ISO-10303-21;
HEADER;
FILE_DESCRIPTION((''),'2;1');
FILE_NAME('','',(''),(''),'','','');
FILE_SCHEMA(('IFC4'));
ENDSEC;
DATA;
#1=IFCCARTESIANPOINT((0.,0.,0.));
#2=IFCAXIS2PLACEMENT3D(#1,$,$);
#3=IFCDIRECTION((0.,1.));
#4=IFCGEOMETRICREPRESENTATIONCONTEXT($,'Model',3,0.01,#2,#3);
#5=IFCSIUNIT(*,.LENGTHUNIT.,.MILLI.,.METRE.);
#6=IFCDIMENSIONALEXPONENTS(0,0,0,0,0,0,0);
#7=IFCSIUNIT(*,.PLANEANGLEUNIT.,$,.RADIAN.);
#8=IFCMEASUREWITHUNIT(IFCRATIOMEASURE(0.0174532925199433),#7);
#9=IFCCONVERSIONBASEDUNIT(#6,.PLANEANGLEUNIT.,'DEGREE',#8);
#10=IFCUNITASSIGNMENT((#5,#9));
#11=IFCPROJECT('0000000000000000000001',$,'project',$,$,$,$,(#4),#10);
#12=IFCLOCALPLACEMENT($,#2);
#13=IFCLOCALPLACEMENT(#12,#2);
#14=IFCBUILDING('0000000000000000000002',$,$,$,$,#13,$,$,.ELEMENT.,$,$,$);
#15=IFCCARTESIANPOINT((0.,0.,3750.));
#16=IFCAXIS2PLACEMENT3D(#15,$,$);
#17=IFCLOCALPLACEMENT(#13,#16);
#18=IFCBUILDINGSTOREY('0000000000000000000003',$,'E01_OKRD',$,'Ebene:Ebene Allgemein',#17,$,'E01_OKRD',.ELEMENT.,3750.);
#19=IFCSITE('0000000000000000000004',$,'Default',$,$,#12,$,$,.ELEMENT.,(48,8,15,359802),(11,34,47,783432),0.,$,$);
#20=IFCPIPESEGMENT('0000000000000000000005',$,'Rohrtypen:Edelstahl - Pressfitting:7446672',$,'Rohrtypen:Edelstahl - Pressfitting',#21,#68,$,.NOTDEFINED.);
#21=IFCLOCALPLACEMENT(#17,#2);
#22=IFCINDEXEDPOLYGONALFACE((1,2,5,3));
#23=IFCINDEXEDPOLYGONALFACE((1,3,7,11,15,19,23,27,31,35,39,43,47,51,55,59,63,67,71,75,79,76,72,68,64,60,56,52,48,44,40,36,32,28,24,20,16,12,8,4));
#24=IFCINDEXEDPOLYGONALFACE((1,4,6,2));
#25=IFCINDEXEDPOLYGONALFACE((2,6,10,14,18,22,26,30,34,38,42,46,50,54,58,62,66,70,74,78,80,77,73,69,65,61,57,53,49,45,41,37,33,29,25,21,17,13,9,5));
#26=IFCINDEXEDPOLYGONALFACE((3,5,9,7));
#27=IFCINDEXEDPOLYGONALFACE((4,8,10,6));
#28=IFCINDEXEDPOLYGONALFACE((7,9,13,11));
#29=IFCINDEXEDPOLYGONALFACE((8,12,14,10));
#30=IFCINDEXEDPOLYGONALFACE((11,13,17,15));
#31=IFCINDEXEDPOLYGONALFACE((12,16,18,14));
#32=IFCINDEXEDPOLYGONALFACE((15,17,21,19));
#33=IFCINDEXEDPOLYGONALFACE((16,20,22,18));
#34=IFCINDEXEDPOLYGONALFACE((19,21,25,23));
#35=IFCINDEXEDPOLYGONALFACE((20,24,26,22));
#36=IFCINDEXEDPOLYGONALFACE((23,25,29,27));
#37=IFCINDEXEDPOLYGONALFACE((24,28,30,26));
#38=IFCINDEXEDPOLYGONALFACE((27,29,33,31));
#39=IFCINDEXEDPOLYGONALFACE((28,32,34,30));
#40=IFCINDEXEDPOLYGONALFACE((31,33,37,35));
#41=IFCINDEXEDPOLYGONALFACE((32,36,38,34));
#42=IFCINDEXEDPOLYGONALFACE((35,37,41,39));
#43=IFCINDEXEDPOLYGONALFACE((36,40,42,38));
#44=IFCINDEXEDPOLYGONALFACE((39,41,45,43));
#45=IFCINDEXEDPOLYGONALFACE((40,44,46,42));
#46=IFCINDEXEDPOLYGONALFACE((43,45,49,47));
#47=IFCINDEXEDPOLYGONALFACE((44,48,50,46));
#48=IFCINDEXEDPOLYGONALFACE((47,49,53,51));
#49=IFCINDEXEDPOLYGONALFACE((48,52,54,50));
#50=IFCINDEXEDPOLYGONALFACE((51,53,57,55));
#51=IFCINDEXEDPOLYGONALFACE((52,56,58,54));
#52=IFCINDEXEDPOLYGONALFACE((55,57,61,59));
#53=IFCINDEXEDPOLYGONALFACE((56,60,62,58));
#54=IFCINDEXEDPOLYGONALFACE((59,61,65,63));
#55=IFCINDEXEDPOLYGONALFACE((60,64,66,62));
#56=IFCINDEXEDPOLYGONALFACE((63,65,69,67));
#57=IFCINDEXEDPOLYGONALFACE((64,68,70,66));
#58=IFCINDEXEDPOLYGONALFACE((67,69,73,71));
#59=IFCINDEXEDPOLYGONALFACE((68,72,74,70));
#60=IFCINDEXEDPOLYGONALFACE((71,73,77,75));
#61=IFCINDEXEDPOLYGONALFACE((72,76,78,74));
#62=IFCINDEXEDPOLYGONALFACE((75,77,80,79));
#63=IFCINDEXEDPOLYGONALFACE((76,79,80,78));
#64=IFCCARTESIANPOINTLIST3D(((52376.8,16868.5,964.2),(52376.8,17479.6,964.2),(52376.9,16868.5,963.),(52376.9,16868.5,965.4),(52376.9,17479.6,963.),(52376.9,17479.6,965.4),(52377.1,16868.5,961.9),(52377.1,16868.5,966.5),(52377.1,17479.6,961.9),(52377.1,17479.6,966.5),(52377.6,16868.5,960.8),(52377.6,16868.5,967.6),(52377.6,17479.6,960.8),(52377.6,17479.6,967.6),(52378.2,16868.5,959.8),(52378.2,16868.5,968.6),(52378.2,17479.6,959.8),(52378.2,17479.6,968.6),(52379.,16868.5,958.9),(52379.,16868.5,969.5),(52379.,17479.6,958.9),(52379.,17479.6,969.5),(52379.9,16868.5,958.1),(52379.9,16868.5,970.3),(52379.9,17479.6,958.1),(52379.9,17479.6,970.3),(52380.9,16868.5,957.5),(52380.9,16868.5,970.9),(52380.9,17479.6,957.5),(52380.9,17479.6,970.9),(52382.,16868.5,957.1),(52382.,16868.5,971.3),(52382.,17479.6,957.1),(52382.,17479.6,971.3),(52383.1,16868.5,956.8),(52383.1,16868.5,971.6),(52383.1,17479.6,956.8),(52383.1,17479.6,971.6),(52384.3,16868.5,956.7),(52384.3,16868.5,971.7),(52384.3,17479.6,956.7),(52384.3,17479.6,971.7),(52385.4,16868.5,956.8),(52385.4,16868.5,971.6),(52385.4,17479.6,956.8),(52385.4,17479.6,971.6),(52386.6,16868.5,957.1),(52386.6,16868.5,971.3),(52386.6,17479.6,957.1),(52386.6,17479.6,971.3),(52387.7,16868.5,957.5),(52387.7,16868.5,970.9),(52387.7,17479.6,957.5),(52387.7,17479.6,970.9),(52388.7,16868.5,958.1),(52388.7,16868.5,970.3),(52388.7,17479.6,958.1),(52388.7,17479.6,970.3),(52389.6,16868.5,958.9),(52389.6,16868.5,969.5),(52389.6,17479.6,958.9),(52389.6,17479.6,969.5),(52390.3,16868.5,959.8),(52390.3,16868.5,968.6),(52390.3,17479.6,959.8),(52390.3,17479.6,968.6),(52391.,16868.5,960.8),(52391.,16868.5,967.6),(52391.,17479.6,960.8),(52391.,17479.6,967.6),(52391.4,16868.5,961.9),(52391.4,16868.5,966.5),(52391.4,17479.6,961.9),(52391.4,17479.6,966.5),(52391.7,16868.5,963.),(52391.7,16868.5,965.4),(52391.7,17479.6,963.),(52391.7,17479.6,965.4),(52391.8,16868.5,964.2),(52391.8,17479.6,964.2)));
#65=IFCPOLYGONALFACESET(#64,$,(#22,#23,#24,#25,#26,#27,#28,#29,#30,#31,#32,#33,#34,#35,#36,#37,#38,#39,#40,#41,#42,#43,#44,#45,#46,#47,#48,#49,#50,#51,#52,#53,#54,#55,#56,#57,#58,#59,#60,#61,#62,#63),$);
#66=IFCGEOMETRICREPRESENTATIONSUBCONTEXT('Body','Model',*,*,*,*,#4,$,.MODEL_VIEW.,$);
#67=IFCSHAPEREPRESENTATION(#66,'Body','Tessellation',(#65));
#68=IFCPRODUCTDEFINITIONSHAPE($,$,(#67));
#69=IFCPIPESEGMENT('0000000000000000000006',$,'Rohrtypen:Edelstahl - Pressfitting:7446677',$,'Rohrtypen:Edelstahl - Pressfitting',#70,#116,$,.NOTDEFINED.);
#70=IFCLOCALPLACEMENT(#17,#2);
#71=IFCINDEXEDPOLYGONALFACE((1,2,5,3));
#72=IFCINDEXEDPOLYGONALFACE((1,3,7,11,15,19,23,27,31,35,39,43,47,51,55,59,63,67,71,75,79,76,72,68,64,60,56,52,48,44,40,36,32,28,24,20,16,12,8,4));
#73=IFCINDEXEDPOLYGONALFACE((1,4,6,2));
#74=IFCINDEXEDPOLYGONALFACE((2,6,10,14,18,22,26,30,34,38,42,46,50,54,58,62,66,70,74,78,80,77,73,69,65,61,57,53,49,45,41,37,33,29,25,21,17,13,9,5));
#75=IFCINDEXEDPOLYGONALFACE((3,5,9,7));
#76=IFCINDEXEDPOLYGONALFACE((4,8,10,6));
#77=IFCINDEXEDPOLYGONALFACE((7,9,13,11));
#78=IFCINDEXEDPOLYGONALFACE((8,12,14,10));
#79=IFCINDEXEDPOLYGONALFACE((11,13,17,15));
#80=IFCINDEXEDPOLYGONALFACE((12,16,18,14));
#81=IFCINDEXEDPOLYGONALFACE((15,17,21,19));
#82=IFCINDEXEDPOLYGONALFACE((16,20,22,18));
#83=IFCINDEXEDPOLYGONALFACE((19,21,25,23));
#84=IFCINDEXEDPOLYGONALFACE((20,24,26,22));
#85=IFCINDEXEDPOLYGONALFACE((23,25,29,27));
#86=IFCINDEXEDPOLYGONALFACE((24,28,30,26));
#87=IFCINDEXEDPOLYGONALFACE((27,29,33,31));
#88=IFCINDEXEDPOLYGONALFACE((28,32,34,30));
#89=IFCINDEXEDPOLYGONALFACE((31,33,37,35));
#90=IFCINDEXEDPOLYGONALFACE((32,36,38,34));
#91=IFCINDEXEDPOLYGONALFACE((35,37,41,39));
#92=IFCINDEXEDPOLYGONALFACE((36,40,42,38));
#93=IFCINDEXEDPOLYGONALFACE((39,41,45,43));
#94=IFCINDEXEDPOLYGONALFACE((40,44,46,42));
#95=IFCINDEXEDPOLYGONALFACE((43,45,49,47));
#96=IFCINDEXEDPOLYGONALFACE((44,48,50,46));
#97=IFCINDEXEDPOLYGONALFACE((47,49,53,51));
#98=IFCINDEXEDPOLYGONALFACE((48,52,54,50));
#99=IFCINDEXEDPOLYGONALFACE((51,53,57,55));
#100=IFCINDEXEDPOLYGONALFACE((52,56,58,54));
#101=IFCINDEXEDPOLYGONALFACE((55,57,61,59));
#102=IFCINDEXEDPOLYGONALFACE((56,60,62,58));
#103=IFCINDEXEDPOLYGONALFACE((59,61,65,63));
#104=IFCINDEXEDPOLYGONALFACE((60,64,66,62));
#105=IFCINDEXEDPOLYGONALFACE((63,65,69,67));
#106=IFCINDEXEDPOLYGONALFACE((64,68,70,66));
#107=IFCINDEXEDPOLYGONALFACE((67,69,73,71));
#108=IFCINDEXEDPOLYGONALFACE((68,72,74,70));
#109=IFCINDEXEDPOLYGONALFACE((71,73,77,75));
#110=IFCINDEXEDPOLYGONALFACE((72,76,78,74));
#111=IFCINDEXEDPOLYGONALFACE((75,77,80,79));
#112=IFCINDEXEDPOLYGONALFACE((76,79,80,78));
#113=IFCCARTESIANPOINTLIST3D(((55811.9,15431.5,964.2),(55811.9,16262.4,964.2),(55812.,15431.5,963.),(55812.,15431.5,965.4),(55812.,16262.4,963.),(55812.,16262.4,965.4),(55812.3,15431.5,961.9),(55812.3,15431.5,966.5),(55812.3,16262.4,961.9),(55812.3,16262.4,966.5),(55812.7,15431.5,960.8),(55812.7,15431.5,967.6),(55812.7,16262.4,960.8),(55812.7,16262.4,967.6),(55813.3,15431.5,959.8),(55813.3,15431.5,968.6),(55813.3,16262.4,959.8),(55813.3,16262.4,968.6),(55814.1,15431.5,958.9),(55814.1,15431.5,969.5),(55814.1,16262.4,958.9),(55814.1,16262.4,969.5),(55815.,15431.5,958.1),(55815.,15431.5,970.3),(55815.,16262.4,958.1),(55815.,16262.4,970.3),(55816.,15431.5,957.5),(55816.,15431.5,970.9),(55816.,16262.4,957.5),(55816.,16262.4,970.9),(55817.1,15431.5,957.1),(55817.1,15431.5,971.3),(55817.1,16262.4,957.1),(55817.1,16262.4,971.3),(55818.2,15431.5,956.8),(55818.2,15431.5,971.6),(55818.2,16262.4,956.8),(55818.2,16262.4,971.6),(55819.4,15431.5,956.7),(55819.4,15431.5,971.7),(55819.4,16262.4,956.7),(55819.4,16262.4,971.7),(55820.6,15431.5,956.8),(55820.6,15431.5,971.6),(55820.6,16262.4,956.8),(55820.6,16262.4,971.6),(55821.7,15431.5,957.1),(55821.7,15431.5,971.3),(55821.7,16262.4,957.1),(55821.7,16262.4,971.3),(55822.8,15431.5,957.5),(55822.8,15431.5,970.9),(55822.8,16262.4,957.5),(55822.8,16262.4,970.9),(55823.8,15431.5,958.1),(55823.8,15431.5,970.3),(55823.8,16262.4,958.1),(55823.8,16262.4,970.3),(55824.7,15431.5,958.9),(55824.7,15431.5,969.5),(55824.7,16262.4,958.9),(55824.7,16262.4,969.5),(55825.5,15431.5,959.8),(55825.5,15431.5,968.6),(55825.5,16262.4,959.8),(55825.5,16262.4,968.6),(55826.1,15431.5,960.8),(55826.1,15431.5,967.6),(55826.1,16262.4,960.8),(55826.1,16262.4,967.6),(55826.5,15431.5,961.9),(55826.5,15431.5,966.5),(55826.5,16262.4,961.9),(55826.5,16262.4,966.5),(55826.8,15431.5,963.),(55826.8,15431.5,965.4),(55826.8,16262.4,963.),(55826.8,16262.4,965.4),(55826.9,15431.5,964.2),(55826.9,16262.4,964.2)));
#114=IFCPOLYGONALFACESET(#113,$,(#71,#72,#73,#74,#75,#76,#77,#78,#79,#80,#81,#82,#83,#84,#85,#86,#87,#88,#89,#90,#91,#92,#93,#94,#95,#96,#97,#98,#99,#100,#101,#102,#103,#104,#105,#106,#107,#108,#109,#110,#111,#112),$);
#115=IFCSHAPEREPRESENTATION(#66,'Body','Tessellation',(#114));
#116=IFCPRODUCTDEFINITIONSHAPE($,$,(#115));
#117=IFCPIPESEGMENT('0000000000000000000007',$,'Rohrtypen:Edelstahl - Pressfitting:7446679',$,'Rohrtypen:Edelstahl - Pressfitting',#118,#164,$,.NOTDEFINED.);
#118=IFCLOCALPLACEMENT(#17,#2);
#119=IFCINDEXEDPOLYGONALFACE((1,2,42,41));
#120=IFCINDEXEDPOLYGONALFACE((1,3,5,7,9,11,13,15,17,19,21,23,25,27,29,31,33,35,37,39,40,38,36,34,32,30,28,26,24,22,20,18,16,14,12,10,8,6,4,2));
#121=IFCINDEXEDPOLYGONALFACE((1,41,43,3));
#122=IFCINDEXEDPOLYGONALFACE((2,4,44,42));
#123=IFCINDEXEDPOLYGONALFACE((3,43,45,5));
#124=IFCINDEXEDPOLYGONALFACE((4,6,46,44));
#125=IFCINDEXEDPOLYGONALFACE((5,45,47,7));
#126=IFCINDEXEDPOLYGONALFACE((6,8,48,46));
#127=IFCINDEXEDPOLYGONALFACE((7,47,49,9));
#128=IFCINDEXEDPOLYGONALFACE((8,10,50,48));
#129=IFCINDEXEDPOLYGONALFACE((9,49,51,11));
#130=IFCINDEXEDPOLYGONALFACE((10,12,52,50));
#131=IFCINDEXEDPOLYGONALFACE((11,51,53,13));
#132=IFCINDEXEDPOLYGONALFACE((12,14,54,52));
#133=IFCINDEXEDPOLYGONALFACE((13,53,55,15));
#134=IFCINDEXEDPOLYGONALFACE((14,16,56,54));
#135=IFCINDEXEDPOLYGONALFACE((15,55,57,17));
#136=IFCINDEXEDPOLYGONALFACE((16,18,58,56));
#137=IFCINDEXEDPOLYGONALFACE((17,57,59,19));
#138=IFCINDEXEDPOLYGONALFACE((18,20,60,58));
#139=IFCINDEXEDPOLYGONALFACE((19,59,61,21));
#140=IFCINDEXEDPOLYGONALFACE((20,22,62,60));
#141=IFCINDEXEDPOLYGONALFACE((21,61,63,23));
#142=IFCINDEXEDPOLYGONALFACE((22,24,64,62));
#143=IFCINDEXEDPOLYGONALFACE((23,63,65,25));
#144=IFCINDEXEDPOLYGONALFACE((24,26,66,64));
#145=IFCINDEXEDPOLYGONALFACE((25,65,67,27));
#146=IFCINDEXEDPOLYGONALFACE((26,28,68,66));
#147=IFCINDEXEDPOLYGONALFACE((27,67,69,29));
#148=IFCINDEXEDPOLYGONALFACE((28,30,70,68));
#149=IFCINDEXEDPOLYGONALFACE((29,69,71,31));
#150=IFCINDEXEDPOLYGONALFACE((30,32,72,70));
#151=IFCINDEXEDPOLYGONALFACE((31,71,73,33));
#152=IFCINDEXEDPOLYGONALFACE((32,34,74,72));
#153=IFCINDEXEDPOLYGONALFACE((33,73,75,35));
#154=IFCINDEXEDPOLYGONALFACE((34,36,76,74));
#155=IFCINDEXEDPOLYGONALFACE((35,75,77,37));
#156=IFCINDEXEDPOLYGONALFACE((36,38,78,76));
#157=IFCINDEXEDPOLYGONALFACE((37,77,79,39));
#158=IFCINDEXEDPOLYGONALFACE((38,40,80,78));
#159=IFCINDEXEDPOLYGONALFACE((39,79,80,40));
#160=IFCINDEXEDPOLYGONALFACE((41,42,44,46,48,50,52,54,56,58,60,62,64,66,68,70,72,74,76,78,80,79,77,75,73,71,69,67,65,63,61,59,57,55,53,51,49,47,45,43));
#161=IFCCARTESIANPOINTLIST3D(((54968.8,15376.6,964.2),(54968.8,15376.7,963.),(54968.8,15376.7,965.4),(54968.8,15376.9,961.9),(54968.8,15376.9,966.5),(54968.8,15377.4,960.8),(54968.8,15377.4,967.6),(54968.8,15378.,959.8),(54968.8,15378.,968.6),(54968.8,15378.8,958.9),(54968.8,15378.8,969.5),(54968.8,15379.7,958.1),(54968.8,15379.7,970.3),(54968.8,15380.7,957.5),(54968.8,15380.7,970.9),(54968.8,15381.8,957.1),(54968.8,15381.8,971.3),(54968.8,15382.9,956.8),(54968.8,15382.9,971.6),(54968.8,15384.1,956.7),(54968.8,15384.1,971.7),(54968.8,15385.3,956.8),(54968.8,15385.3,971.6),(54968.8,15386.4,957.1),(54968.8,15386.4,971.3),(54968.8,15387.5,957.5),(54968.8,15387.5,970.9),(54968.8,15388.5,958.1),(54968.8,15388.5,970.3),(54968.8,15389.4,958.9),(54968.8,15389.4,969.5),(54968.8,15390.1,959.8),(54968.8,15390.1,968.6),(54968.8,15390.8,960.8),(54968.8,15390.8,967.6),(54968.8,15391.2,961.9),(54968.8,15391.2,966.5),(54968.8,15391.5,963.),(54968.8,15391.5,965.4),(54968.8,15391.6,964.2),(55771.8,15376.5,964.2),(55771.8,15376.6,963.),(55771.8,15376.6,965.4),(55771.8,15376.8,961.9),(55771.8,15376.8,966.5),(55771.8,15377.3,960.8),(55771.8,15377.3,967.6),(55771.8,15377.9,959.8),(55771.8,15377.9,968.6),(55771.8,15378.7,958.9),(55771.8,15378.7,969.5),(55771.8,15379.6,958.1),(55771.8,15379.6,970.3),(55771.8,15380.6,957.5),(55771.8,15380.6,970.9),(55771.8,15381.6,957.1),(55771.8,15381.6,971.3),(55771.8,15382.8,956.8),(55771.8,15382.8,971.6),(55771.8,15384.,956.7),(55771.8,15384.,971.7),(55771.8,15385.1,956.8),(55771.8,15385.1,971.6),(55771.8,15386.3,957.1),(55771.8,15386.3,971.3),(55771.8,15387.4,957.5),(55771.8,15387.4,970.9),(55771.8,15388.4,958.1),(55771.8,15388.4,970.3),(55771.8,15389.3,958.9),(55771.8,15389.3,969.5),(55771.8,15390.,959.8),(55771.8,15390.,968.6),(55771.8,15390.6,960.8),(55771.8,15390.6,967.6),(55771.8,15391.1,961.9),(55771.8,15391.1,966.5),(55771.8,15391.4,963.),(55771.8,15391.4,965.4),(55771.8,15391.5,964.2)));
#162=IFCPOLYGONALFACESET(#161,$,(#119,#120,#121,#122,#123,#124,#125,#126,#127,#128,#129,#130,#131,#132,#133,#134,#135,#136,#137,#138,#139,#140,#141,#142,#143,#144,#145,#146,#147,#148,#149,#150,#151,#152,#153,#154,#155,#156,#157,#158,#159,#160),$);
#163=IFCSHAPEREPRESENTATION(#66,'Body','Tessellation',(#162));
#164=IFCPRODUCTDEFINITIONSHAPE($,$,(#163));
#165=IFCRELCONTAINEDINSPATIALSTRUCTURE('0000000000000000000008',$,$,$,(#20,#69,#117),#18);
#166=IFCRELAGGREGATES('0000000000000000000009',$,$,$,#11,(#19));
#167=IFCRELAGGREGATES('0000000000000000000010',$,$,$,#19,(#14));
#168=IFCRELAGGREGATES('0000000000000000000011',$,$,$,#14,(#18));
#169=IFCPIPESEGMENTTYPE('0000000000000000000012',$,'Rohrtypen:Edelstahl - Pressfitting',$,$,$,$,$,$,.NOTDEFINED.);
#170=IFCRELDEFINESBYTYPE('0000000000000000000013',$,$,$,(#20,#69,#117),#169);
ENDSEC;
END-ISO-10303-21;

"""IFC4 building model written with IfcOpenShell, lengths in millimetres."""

from ifc_helpers import new_model, entity, si_unit, converted_unit, direction, frame, origin, place, context, subcontext, project, spatial, indexed_curve, outline, extrude, type_object, element, save


model = new_model("IFC4")

# Units and contexts
model_context = context("Model", 3, precision=0.01, world=origin(), true_north=direction((0.0, 1.0)))
body_context = subcontext(model_context, "Body", "Model", "MODEL_VIEW")
ifc_project = project(units=[si_unit("LENGTHUNIT", "METRE", prefix="MILLI"), converted_unit("PLANEANGLEUNIT", "DEGREE", entity("IfcRatioMeasure", 0.0174532925199433), si_unit("PLANEANGLEUNIT", "RADIAN"), dimensions=[0, 0, 0, 0, 0, 0, 0])], contexts=[model_context])

# Site, building, storey
site_placement = place(None, origin())
site = spatial("IfcSite", under=ifc_project, at=site_placement, Name="Default", CompositionType="ELEMENT", RefLatitude=(48, 8, 15, 359802), RefLongitude=(11, 34, 47, 783432), RefElevation=0.0)
building_placement = place(site_placement, origin())
building = spatial("IfcBuilding", under=site, at=building_placement, CompositionType="ELEMENT")
storey_placement = place(building_placement, frame((0.0, 0.0, 3750.0)))
storey = spatial("IfcBuildingStorey", under=building, at=storey_placement, Name="E01_OKRD", ObjectType="Ebene:Ebene Allgemein", LongName="E01_OKRD", CompositionType="ELEMENT", Elevation=3750.0)

# Pipe segments
pipe_segment_type_1 = type_object("IfcPipeSegmentType", Name="Rohrtypen:Edelstahl - Pressfitting", PredefinedType="NOTDEFINED")
pipe_segment_1_placement = place(storey_placement, origin())
element("IfcPipeSegment", 1, at=pipe_segment_1_placement, inside=storey, type_object=pipe_segment_type_1, Name="Rohrtypen:Edelstahl - Pressfitting:7446672", ObjectType="Rohrtypen:Edelstahl - Pressfitting", PredefinedType="NOTDEFINED", context=body_context, shape_type="SweptSolid", body=[
    extrude(outline(indexed_curve([(7.5, 0.0), (7.4, 1.2), (7.1, 2.3), (6.7, 3.4), (6.1, 4.4), (5.3, 5.3), (4.4, 6.1), (3.4, 6.7), (2.3, 7.1), (1.2, 7.4), (0.0, 7.5), (-1.2, 7.4), (-2.3, 7.1), (-3.4, 6.7), (-4.4, 6.1), (-5.3, 5.3), (-6.1, 4.4), (-6.7, 3.4), (-7.1, 2.3), (-7.4, 1.2), (-7.5, 0.0), (-7.4, -1.2), (-7.1, -2.3), (-6.7, -3.4), (-6.1, -4.4), (-5.3, -5.3), (-4.4, -6.1), (-3.4, -6.7), (-2.3, -7.1), (-1.2, -7.4), (0.0, -7.5), (1.2, -7.4), (2.3, -7.1), (3.4, -6.7), (4.4, -6.1), (5.3, -5.3), (6.1, -4.4), (6.7, -3.4), (7.1, -2.3), (7.4, -1.2), (7.5, 0.0)], self_intersect=False)), frame((52384.3, 16868.5, 964.2), z_axis=(0.000001, 1.0, 0.0), x_axis=(1.0, -0.000001, 0.0)), (0.0, 0.0, 1.0), 611.0),
])
pipe_segment_2_placement = place(storey_placement, origin())
element("IfcPipeSegment", 2, at=pipe_segment_2_placement, inside=storey, type_object=pipe_segment_type_1, Name="Rohrtypen:Edelstahl - Pressfitting:7446677", ObjectType="Rohrtypen:Edelstahl - Pressfitting", PredefinedType="NOTDEFINED", context=body_context, shape_type="SweptSolid", body=[
    extrude(outline(indexed_curve([(7.5, 0.0), (7.4, 1.2), (7.1, 2.3), (6.7, 3.4), (6.1, 4.4), (5.3, 5.3), (4.4, 6.1), (3.4, 6.7), (2.3, 7.1), (1.2, 7.4), (0.0, 7.5), (-1.2, 7.4), (-2.3, 7.1), (-3.4, 6.7), (-4.4, 6.1), (-5.3, 5.3), (-6.1, 4.4), (-6.7, 3.4), (-7.1, 2.3), (-7.4, 1.2), (-7.5, 0.0), (-7.4, -1.2), (-7.1, -2.3), (-6.7, -3.4), (-6.1, -4.4), (-5.3, -5.3), (-4.4, -6.1), (-3.4, -6.7), (-2.3, -7.1), (-1.2, -7.4), (0.0, -7.5), (1.2, -7.4), (2.3, -7.1), (3.4, -6.7), (4.4, -6.1), (5.3, -5.3), (6.1, -4.4), (6.7, -3.4), (7.1, -2.3), (7.4, -1.2), (7.5, 0.0)], self_intersect=False)), frame((55819.4, 15431.5, 964.2), z_axis=(-0.000004, 1.0, 0.0), x_axis=(-1.0, -0.000004, 0.0)), (0.0, 0.0, 1.0), 830.9),
])
pipe_segment_3_placement = place(storey_placement, origin())
element("IfcPipeSegment", 3, at=pipe_segment_3_placement, inside=storey, type_object=pipe_segment_type_1, Name="Rohrtypen:Edelstahl - Pressfitting:7446679", ObjectType="Rohrtypen:Edelstahl - Pressfitting", PredefinedType="NOTDEFINED", context=body_context, shape_type="SweptSolid", body=[
    extrude(outline(indexed_curve([(7.5, 0.0), (7.4, 1.2), (7.1, 2.3), (6.7, 3.4), (6.1, 4.4), (5.3, 5.3), (4.4, 6.1), (3.4, 6.7), (2.3, 7.1), (1.2, 7.4), (0.0, 7.5), (-1.2, 7.4), (-2.3, 7.1), (-3.4, 6.7), (-4.4, 6.1), (-5.3, 5.3), (-6.1, 4.4), (-6.7, 3.4), (-7.1, 2.3), (-7.4, 1.2), (-7.5, 0.0), (-7.4, -1.2), (-7.1, -2.3), (-6.7, -3.4), (-6.1, -4.4), (-5.3, -5.3), (-4.4, -6.1), (-3.4, -6.7), (-2.3, -7.1), (-1.2, -7.4), (0.0, -7.5), (1.2, -7.4), (2.3, -7.1), (3.4, -6.7), (4.4, -6.1), (5.3, -5.3), (6.1, -4.4), (6.7, -3.4), (7.1, -2.3), (7.4, -1.2), (7.5, 0.0)], self_intersect=False)), frame((54968.8, 15384.1, 964.2), z_axis=(1.0, -0.000148, 0.0), x_axis=(0.000148, 1.0, 0.0)), (0.0, 0.0, 1.0), 803.0),
])

save(model, "model.ifc")
